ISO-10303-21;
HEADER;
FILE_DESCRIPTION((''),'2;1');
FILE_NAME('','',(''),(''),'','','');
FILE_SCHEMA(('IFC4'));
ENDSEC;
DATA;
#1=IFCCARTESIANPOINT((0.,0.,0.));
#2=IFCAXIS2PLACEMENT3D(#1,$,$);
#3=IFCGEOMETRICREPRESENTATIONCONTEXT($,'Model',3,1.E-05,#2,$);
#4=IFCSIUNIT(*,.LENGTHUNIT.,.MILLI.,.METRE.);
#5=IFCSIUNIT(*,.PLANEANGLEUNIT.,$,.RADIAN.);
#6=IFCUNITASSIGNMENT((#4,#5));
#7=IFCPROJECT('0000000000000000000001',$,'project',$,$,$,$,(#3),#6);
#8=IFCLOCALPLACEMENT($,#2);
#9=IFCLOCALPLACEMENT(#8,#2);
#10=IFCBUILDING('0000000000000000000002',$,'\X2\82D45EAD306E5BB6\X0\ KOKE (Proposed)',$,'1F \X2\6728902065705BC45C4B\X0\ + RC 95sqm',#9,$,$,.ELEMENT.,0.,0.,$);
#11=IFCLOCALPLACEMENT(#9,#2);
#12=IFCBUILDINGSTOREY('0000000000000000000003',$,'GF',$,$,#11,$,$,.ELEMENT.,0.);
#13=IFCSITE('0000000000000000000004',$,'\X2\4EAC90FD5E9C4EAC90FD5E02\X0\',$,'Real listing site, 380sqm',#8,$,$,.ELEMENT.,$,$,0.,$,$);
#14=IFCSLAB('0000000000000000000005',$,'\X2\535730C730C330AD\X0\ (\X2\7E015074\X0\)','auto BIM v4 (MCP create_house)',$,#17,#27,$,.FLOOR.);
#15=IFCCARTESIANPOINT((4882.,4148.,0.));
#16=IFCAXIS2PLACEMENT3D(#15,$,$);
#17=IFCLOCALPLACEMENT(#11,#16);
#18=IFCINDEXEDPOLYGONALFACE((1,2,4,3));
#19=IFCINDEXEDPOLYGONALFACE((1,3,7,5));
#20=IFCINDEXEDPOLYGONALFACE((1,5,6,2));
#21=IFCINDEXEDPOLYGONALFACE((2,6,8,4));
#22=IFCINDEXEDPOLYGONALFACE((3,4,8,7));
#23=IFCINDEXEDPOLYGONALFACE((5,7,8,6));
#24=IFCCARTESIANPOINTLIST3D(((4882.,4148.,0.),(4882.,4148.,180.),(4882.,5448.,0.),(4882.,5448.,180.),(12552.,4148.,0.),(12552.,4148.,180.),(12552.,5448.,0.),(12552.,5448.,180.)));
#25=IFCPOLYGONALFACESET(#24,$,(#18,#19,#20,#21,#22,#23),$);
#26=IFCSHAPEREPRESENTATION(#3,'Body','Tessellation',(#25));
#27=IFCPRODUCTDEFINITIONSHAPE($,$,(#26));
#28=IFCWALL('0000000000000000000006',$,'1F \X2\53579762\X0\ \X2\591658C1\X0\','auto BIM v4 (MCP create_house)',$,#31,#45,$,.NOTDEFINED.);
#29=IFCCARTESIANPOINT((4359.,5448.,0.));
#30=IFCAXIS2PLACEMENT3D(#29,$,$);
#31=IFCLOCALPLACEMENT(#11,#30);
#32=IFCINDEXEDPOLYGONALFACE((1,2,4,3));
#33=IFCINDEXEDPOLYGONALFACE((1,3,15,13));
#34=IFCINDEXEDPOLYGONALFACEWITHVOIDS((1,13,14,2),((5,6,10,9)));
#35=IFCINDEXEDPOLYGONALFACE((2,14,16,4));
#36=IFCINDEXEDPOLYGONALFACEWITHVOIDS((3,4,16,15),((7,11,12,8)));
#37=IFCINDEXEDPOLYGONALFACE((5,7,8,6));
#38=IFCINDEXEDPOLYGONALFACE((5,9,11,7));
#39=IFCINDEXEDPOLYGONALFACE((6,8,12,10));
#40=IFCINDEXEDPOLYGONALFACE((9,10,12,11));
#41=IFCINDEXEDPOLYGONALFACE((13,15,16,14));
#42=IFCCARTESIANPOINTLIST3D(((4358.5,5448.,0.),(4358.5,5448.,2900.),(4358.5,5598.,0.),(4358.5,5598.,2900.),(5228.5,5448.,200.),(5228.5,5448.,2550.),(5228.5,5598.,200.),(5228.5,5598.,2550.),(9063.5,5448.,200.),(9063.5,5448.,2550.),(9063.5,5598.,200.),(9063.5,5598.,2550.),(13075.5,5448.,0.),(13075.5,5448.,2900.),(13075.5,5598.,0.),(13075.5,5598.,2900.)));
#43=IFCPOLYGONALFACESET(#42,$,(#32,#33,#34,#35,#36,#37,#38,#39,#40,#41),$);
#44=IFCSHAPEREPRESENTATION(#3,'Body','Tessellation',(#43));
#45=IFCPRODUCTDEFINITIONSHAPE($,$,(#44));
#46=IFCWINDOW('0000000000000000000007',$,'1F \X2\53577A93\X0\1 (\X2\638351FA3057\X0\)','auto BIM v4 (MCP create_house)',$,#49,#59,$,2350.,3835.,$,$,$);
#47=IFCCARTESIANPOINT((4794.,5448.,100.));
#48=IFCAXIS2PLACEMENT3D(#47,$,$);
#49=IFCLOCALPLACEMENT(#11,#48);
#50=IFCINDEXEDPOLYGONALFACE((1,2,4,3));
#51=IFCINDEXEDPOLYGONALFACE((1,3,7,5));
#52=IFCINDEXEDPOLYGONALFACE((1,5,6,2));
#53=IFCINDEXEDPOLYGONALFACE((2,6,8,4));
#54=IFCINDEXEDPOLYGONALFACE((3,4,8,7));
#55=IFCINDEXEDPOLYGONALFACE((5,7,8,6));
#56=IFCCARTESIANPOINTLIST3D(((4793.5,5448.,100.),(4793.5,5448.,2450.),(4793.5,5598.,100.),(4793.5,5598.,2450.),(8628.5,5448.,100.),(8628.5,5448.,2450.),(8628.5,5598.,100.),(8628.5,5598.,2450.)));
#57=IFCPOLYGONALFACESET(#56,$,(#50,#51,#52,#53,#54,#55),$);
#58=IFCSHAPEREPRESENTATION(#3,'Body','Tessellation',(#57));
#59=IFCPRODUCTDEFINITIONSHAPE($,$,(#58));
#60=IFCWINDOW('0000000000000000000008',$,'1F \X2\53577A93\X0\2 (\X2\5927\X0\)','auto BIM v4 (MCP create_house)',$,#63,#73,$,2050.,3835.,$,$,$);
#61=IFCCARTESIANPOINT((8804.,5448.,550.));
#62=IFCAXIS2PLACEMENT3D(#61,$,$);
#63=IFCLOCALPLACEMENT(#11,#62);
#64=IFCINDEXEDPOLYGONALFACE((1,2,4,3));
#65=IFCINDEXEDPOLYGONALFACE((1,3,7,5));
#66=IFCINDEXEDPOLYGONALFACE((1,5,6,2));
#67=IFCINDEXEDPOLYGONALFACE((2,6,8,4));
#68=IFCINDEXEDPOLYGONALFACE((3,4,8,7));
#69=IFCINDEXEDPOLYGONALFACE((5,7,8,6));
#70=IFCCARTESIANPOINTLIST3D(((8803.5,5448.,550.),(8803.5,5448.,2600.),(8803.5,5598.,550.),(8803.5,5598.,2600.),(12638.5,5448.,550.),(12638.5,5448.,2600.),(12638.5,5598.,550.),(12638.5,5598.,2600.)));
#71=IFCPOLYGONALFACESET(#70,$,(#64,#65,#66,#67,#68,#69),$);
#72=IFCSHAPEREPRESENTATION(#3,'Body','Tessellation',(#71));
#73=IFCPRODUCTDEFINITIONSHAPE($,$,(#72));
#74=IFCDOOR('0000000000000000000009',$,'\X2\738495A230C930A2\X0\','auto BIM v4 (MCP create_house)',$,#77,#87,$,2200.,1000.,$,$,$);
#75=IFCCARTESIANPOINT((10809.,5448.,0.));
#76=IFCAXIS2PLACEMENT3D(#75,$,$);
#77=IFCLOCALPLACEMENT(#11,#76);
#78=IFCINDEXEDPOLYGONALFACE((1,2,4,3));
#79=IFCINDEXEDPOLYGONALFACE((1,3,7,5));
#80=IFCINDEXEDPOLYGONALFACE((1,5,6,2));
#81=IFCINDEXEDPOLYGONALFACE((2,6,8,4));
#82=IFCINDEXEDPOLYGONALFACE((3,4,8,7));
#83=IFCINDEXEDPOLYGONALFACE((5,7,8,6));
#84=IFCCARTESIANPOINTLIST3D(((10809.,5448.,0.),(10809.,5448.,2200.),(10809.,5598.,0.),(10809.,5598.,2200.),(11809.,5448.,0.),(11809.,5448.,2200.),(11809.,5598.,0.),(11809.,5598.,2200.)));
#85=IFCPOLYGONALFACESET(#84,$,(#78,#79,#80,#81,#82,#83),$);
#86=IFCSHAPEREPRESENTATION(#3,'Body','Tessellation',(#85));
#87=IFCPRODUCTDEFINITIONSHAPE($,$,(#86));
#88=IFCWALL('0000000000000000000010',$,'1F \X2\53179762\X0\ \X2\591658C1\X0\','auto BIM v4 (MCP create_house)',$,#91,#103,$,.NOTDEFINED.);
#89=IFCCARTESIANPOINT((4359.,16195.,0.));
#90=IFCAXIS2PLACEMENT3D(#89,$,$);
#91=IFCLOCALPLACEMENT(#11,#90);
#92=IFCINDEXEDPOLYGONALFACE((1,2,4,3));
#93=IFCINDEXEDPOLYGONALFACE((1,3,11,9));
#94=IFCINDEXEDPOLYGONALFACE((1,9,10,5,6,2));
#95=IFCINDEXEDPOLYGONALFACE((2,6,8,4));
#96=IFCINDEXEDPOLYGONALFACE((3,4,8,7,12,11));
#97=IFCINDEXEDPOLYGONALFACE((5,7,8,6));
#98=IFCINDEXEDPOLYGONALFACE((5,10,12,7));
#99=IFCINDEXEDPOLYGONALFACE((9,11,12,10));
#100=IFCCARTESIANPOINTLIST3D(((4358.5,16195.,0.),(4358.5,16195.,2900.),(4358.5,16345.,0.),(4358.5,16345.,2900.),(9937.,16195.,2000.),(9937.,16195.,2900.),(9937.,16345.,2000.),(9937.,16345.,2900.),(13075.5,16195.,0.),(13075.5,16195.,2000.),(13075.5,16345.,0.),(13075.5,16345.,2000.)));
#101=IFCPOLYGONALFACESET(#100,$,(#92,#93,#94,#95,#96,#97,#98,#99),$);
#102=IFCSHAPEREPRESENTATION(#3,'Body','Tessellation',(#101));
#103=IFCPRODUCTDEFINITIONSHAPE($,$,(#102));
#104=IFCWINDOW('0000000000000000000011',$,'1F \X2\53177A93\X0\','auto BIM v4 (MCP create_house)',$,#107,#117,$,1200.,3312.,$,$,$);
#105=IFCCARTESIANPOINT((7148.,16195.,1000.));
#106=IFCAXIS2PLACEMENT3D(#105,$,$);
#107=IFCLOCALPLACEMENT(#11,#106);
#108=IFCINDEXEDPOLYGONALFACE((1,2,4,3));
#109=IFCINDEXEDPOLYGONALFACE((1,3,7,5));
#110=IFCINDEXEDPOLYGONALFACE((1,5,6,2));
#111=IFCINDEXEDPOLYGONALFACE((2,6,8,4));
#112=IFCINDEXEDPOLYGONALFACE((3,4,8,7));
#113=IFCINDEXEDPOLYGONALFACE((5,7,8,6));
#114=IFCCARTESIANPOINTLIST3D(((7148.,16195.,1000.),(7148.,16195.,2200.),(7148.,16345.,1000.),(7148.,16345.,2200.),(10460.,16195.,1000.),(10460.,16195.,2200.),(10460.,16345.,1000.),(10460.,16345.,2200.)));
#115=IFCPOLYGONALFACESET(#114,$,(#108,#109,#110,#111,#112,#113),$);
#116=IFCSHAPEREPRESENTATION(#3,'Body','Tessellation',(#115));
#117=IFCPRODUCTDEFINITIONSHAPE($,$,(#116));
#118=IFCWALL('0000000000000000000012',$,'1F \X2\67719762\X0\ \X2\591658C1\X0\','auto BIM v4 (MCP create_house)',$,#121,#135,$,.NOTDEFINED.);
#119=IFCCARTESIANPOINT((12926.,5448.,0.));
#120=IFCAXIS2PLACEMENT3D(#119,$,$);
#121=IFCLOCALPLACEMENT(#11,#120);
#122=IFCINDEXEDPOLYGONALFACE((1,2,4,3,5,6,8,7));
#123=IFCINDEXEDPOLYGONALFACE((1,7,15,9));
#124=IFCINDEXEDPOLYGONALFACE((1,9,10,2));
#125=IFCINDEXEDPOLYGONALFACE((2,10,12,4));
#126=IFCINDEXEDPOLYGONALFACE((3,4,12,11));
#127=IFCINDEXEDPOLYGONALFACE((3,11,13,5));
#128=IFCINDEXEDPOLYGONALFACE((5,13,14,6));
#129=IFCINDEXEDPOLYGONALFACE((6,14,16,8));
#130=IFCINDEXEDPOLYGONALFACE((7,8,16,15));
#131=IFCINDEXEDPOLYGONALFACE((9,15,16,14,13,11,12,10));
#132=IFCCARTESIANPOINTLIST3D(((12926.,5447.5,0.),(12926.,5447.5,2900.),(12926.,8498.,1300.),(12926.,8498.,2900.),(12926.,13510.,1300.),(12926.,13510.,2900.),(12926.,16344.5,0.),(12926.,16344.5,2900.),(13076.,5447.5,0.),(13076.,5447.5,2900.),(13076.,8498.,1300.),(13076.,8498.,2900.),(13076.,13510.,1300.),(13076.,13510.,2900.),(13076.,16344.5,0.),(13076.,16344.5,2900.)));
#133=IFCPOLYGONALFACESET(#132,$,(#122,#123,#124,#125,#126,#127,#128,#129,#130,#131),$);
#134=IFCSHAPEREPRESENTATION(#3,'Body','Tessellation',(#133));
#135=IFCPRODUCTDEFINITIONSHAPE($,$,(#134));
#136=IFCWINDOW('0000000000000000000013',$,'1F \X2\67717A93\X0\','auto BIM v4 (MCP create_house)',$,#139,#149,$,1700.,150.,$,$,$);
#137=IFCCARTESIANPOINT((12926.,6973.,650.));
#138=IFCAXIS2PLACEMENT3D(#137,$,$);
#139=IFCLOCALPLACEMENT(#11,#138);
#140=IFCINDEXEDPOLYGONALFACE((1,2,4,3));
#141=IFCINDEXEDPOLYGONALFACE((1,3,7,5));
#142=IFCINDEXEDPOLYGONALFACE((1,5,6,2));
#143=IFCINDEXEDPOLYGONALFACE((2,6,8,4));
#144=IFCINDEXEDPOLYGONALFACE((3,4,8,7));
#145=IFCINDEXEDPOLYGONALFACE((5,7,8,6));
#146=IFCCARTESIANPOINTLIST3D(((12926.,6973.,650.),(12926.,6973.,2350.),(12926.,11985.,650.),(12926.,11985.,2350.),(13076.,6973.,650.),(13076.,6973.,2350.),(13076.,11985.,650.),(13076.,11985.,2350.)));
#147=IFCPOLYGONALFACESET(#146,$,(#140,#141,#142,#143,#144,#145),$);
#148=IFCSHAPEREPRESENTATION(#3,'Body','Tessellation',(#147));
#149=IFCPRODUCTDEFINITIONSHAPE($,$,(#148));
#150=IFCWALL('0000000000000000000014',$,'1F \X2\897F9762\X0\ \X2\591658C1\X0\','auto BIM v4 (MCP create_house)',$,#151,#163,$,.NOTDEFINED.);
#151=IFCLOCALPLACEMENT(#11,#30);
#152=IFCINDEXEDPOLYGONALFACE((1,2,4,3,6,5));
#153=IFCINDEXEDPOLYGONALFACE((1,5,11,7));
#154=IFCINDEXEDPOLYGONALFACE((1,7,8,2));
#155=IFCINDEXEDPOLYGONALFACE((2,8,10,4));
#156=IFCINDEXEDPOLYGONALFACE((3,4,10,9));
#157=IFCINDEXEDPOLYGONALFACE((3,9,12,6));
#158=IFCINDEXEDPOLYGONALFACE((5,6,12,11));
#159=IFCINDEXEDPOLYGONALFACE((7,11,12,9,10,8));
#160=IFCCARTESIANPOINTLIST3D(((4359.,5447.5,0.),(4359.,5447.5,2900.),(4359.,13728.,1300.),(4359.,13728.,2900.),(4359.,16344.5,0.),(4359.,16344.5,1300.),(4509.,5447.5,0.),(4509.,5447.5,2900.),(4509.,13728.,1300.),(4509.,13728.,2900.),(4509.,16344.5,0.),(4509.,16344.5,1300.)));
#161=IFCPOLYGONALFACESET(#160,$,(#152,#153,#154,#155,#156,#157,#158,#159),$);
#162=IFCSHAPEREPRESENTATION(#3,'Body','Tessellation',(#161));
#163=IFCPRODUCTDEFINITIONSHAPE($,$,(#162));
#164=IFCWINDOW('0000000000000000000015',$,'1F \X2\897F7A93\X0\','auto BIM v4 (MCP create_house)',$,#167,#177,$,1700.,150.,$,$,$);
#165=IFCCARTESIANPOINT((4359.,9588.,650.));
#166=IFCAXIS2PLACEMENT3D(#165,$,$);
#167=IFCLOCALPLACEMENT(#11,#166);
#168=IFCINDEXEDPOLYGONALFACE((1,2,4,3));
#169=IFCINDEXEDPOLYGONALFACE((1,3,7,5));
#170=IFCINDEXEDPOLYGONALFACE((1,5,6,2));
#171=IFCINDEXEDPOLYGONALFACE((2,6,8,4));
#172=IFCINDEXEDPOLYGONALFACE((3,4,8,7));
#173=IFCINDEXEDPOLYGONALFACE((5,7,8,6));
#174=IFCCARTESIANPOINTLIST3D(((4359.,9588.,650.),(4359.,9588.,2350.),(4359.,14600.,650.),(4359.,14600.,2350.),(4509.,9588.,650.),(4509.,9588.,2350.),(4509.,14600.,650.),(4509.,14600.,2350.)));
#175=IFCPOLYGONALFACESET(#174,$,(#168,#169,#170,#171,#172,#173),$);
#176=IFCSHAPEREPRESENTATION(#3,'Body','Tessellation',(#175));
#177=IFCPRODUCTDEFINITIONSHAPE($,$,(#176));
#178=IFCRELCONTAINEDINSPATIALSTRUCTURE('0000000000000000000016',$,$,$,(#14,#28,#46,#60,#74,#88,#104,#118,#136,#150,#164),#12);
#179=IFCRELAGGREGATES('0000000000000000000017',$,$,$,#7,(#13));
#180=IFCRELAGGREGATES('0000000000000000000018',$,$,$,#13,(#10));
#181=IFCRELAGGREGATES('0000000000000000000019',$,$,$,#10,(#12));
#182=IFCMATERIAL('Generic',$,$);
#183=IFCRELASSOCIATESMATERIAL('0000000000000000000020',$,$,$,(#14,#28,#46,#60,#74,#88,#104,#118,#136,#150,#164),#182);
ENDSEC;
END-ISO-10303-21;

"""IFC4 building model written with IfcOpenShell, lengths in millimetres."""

from ifc_helpers import new_model, si_unit, frame, frame_2d, origin, place, context, project, spatial, rectangle, extrude, material, element, fill, save


model = new_model("IFC4")

# Units and contexts
model_context = context("Model", 3, precision=1e-05, world=origin())
ifc_project = project(units=[si_unit("LENGTHUNIT", "METRE", prefix="MILLI"), si_unit("PLANEANGLEUNIT", "RADIAN")], contexts=[model_context])

# Site, building, storey
site_placement = place(None, origin())
site = spatial("IfcSite", under=ifc_project, at=site_placement, Name="京都府京都市", ObjectType="Real listing site, 380sqm", CompositionType="ELEMENT", RefElevation=0.0)
building_placement = place(site_placement, origin())
building = spatial("IfcBuilding", under=site, at=building_placement, Name="苔庭の家 KOKE (Proposed)", ObjectType="1F 木造数寄屋 + RC 95sqm", CompositionType="ELEMENT", ElevationOfRefHeight=0.0, ElevationOfTerrain=0.0)
storey_placement = place(building_placement, origin())
storey = spatial("IfcBuildingStorey", under=building, at=storey_placement, Name="GF", CompositionType="ELEMENT", Elevation=0.0)

# Slab
ifc_material = material(Name="Generic")
slab_1_placement = place(storey_placement, frame((4882.0, 4148.0, 0.0)))
element("IfcSlab", 1, at=slab_1_placement, inside=storey, material=ifc_material, Name="南デッキ (縁側)", Description="auto BIM v4 (MCP create_house)", PredefinedType="FLOOR", context=model_context, shape_type="SweptSolid", body=[
    extrude(rectangle(XDim=7670.0, YDim=1300.0, at=frame_2d((3835.0, 650.0))), frame((4882.0, 4148.0, 0.0)), (0.0, 0.0, 1.0), 180.0),
])

# Wall, openings, windows, door
wall_1_placement = place(storey_placement, frame((4359.0, 5448.0, 0.0)))
wall_1 = element("IfcWall", 2, at=wall_1_placement, inside=storey, material=ifc_material, Name="1F 南面 外壁", Description="auto BIM v4 (MCP create_house)", PredefinedType="NOTDEFINED", context=model_context, shape_type="SweptSolid", body=[
    extrude(rectangle(XDim=8717.0, YDim=150.0, at=frame_2d((4358.0, 75.0))), frame((4359.0, 5448.0, 0.0)), (0.0, 0.0, 1.0), 2900.0),
])
opening_1_placement = place(storey_placement, frame((4794.0, 5448.0, 100.0)))
opening_1 = element("IfcOpeningElement", 3, at=opening_1_placement, cuts=wall_1, PredefinedType="NOTDEFINED", context=model_context, shape_type="SweptSolid", body=[
    extrude(rectangle(XDim=3835.0, YDim=150.0, at=frame_2d((1917.0, 75.0))), frame((4794.0, 5448.0, 100.0)), (0.0, 0.0, 1.0), 2350.0),
])
opening_2_placement = place(storey_placement, frame((8804.0, 5448.0, 550.0)))
opening_2 = element("IfcOpeningElement", 4, at=opening_2_placement, cuts=wall_1, PredefinedType="NOTDEFINED", context=model_context, shape_type="SweptSolid", body=[
    extrude(rectangle(XDim=3835.0, YDim=150.0, at=frame_2d((1917.0, 75.0))), frame((8804.0, 5448.0, 550.0)), (0.0, 0.0, 1.0), 2050.0),
])
opening_3_placement = place(storey_placement, frame((10809.0, 5448.0, 0.0)))
opening_3 = element("IfcOpeningElement", 5, at=opening_3_placement, cuts=wall_1, PredefinedType="NOTDEFINED", context=model_context, shape_type="SweptSolid", body=[
    extrude(rectangle(XDim=1000.0, YDim=150.0, at=frame_2d((500.0, 75.0))), frame((10809.0, 5448.0, 0.0)), (0.0, 0.0, 1.0), 2200.0),
])
window_1_placement = place(storey_placement, frame((4794.0, 5448.0, 100.0)))
window_1 = element("IfcWindow", 6, at=window_1_placement, inside=storey, material=ifc_material, Name="1F 南窓1 (掃出し)", Description="auto BIM v4 (MCP create_house)", OverallHeight=2350.0, OverallWidth=3835.0, context=model_context, shape_type="SweptSolid", body=[
    extrude(rectangle(XDim=3835.0, YDim=150.0, at=frame_2d((1917.0, 75.0))), frame((4794.0, 5448.0, 100.0)), (0.0, 0.0, 1.0), 2350.0),
])
fill(opening_1, window_1)
window_2_placement = place(storey_placement, frame((8804.0, 5448.0, 550.0)))
window_2 = element("IfcWindow", 7, at=window_2_placement, inside=storey, material=ifc_material, Name="1F 南窓2 (大)", Description="auto BIM v4 (MCP create_house)", OverallHeight=2050.0, OverallWidth=3835.0, context=model_context, shape_type="SweptSolid", body=[
    extrude(rectangle(XDim=3835.0, YDim=150.0, at=frame_2d((1917.0, 75.0))), frame((8804.0, 5448.0, 550.0)), (0.0, 0.0, 1.0), 2050.0),
])
fill(opening_2, window_2)
door_placement = place(storey_placement, frame((10809.0, 5448.0, 0.0)))
door = element("IfcDoor", 8, at=door_placement, inside=storey, material=ifc_material, Name="玄関ドア", Description="auto BIM v4 (MCP create_house)", OverallHeight=2200.0, OverallWidth=1000.0, context=model_context, shape_type="SweptSolid", body=[
    extrude(rectangle(XDim=1000.0, YDim=150.0, at=frame_2d((500.0, 75.0))), frame((10809.0, 5448.0, 0.0)), (0.0, 0.0, 1.0), 2200.0),
])
fill(opening_3, door)

# Walls, openings, windows
wall_2_placement = place(storey_placement, frame((4359.0, 16195.0, 0.0)))
wall_2 = element("IfcWall", 9, at=wall_2_placement, inside=storey, material=ifc_material, Name="1F 北面 外壁", Description="auto BIM v4 (MCP create_house)", PredefinedType="NOTDEFINED", context=model_context, shape_type="SweptSolid", body=[
    extrude(rectangle(XDim=8717.0, YDim=150.0, at=frame_2d((4358.0, 75.0))), frame((4359.0, 16195.0, 0.0)), (0.0, 0.0, 1.0), 2900.0),
])
opening_4_placement = place(storey_placement, frame((7148.0, 16195.0, 1000.0)))
opening_4 = element("IfcOpeningElement", 10, at=opening_4_placement, cuts=wall_2, PredefinedType="NOTDEFINED", context=model_context, shape_type="SweptSolid", body=[
    extrude(rectangle(XDim=3312.0, YDim=150.0, at=frame_2d((1656.0, 75.0))), frame((7148.0, 16195.0, 1000.0)), (0.0, 0.0, 1.0), 1200.0),
])
window_3_placement = place(storey_placement, frame((7148.0, 16195.0, 1000.0)))
window_3 = element("IfcWindow", 11, at=window_3_placement, inside=storey, material=ifc_material, Name="1F 北窓", Description="auto BIM v4 (MCP create_house)", OverallHeight=1200.0, OverallWidth=3312.0, context=model_context, shape_type="SweptSolid", body=[
    extrude(rectangle(XDim=3312.0, YDim=150.0, at=frame_2d((1656.0, 75.0))), frame((7148.0, 16195.0, 1000.0)), (0.0, 0.0, 1.0), 1200.0),
])
fill(opening_4, window_3)
wall_3_placement = place(storey_placement, frame((12926.0, 5448.0, 0.0)))
wall_3 = element("IfcWall", 12, at=wall_3_placement, inside=storey, material=ifc_material, Name="1F 東面 外壁", Description="auto BIM v4 (MCP create_house)", PredefinedType="NOTDEFINED", context=model_context, shape_type="SweptSolid", body=[
    extrude(rectangle(XDim=150.0, YDim=10897.0, at=frame_2d((75.0, 5448.0))), frame((12926.0, 5448.0, 0.0)), (0.0, 0.0, 1.0), 2900.0),
])
opening_5_placement = place(storey_placement, frame((12926.0, 6973.0, 650.0)))
opening_5 = element("IfcOpeningElement", 13, at=opening_5_placement, cuts=wall_3, PredefinedType="NOTDEFINED", context=model_context, shape_type="SweptSolid", body=[
    extrude(rectangle(XDim=150.0, YDim=5012.0, at=frame_2d((75.0, 2506.0))), frame((12926.0, 6973.0, 650.0)), (0.0, 0.0, 1.0), 1700.0),
])
window_4_placement = place(storey_placement, frame((12926.0, 6973.0, 650.0)))
window_4 = element("IfcWindow", 14, at=window_4_placement, inside=storey, material=ifc_material, Name="1F 東窓", Description="auto BIM v4 (MCP create_house)", OverallHeight=1700.0, OverallWidth=150.0, context=model_context, shape_type="SweptSolid", body=[
    extrude(rectangle(XDim=150.0, YDim=5012.0, at=frame_2d((75.0, 2506.0))), frame((12926.0, 6973.0, 650.0)), (0.0, 0.0, 1.0), 1700.0),
])
fill(opening_5, window_4)
wall_4_placement = place(storey_placement, frame((4359.0, 5448.0, 0.0)))
wall_4 = element("IfcWall", 15, at=wall_4_placement, inside=storey, material=ifc_material, Name="1F 西面 外壁", Description="auto BIM v4 (MCP create_house)", PredefinedType="NOTDEFINED", context=model_context, shape_type="SweptSolid", body=[
    extrude(rectangle(XDim=150.0, YDim=10897.0, at=frame_2d((75.0, 5448.0))), frame((4359.0, 5448.0, 0.0)), (0.0, 0.0, 1.0), 2900.0),
])
opening_6_placement = place(storey_placement, frame((4359.0, 9588.0, 650.0)))
opening_6 = element("IfcOpeningElement", 16, at=opening_6_placement, cuts=wall_4, PredefinedType="NOTDEFINED", context=model_context, shape_type="SweptSolid", body=[
    extrude(rectangle(XDim=150.0, YDim=5012.0, at=frame_2d((75.0, 2506.0))), frame((4359.0, 9588.0, 650.0)), (0.0, 0.0, 1.0), 1700.0),
])
window_5_placement = place(storey_placement, frame((4359.0, 9588.0, 650.0)))
window_5 = element("IfcWindow", 17, at=window_5_placement, inside=storey, material=ifc_material, Name="1F 西窓", Description="auto BIM v4 (MCP create_house)", OverallHeight=1700.0, OverallWidth=150.0, context=model_context, shape_type="SweptSolid", body=[
    extrude(rectangle(XDim=150.0, YDim=5012.0, at=frame_2d((75.0, 2506.0))), frame((4359.0, 9588.0, 650.0)), (0.0, 0.0, 1.0), 1700.0),
])
fill(opening_6, window_5)

save(model, "model.ifc")
